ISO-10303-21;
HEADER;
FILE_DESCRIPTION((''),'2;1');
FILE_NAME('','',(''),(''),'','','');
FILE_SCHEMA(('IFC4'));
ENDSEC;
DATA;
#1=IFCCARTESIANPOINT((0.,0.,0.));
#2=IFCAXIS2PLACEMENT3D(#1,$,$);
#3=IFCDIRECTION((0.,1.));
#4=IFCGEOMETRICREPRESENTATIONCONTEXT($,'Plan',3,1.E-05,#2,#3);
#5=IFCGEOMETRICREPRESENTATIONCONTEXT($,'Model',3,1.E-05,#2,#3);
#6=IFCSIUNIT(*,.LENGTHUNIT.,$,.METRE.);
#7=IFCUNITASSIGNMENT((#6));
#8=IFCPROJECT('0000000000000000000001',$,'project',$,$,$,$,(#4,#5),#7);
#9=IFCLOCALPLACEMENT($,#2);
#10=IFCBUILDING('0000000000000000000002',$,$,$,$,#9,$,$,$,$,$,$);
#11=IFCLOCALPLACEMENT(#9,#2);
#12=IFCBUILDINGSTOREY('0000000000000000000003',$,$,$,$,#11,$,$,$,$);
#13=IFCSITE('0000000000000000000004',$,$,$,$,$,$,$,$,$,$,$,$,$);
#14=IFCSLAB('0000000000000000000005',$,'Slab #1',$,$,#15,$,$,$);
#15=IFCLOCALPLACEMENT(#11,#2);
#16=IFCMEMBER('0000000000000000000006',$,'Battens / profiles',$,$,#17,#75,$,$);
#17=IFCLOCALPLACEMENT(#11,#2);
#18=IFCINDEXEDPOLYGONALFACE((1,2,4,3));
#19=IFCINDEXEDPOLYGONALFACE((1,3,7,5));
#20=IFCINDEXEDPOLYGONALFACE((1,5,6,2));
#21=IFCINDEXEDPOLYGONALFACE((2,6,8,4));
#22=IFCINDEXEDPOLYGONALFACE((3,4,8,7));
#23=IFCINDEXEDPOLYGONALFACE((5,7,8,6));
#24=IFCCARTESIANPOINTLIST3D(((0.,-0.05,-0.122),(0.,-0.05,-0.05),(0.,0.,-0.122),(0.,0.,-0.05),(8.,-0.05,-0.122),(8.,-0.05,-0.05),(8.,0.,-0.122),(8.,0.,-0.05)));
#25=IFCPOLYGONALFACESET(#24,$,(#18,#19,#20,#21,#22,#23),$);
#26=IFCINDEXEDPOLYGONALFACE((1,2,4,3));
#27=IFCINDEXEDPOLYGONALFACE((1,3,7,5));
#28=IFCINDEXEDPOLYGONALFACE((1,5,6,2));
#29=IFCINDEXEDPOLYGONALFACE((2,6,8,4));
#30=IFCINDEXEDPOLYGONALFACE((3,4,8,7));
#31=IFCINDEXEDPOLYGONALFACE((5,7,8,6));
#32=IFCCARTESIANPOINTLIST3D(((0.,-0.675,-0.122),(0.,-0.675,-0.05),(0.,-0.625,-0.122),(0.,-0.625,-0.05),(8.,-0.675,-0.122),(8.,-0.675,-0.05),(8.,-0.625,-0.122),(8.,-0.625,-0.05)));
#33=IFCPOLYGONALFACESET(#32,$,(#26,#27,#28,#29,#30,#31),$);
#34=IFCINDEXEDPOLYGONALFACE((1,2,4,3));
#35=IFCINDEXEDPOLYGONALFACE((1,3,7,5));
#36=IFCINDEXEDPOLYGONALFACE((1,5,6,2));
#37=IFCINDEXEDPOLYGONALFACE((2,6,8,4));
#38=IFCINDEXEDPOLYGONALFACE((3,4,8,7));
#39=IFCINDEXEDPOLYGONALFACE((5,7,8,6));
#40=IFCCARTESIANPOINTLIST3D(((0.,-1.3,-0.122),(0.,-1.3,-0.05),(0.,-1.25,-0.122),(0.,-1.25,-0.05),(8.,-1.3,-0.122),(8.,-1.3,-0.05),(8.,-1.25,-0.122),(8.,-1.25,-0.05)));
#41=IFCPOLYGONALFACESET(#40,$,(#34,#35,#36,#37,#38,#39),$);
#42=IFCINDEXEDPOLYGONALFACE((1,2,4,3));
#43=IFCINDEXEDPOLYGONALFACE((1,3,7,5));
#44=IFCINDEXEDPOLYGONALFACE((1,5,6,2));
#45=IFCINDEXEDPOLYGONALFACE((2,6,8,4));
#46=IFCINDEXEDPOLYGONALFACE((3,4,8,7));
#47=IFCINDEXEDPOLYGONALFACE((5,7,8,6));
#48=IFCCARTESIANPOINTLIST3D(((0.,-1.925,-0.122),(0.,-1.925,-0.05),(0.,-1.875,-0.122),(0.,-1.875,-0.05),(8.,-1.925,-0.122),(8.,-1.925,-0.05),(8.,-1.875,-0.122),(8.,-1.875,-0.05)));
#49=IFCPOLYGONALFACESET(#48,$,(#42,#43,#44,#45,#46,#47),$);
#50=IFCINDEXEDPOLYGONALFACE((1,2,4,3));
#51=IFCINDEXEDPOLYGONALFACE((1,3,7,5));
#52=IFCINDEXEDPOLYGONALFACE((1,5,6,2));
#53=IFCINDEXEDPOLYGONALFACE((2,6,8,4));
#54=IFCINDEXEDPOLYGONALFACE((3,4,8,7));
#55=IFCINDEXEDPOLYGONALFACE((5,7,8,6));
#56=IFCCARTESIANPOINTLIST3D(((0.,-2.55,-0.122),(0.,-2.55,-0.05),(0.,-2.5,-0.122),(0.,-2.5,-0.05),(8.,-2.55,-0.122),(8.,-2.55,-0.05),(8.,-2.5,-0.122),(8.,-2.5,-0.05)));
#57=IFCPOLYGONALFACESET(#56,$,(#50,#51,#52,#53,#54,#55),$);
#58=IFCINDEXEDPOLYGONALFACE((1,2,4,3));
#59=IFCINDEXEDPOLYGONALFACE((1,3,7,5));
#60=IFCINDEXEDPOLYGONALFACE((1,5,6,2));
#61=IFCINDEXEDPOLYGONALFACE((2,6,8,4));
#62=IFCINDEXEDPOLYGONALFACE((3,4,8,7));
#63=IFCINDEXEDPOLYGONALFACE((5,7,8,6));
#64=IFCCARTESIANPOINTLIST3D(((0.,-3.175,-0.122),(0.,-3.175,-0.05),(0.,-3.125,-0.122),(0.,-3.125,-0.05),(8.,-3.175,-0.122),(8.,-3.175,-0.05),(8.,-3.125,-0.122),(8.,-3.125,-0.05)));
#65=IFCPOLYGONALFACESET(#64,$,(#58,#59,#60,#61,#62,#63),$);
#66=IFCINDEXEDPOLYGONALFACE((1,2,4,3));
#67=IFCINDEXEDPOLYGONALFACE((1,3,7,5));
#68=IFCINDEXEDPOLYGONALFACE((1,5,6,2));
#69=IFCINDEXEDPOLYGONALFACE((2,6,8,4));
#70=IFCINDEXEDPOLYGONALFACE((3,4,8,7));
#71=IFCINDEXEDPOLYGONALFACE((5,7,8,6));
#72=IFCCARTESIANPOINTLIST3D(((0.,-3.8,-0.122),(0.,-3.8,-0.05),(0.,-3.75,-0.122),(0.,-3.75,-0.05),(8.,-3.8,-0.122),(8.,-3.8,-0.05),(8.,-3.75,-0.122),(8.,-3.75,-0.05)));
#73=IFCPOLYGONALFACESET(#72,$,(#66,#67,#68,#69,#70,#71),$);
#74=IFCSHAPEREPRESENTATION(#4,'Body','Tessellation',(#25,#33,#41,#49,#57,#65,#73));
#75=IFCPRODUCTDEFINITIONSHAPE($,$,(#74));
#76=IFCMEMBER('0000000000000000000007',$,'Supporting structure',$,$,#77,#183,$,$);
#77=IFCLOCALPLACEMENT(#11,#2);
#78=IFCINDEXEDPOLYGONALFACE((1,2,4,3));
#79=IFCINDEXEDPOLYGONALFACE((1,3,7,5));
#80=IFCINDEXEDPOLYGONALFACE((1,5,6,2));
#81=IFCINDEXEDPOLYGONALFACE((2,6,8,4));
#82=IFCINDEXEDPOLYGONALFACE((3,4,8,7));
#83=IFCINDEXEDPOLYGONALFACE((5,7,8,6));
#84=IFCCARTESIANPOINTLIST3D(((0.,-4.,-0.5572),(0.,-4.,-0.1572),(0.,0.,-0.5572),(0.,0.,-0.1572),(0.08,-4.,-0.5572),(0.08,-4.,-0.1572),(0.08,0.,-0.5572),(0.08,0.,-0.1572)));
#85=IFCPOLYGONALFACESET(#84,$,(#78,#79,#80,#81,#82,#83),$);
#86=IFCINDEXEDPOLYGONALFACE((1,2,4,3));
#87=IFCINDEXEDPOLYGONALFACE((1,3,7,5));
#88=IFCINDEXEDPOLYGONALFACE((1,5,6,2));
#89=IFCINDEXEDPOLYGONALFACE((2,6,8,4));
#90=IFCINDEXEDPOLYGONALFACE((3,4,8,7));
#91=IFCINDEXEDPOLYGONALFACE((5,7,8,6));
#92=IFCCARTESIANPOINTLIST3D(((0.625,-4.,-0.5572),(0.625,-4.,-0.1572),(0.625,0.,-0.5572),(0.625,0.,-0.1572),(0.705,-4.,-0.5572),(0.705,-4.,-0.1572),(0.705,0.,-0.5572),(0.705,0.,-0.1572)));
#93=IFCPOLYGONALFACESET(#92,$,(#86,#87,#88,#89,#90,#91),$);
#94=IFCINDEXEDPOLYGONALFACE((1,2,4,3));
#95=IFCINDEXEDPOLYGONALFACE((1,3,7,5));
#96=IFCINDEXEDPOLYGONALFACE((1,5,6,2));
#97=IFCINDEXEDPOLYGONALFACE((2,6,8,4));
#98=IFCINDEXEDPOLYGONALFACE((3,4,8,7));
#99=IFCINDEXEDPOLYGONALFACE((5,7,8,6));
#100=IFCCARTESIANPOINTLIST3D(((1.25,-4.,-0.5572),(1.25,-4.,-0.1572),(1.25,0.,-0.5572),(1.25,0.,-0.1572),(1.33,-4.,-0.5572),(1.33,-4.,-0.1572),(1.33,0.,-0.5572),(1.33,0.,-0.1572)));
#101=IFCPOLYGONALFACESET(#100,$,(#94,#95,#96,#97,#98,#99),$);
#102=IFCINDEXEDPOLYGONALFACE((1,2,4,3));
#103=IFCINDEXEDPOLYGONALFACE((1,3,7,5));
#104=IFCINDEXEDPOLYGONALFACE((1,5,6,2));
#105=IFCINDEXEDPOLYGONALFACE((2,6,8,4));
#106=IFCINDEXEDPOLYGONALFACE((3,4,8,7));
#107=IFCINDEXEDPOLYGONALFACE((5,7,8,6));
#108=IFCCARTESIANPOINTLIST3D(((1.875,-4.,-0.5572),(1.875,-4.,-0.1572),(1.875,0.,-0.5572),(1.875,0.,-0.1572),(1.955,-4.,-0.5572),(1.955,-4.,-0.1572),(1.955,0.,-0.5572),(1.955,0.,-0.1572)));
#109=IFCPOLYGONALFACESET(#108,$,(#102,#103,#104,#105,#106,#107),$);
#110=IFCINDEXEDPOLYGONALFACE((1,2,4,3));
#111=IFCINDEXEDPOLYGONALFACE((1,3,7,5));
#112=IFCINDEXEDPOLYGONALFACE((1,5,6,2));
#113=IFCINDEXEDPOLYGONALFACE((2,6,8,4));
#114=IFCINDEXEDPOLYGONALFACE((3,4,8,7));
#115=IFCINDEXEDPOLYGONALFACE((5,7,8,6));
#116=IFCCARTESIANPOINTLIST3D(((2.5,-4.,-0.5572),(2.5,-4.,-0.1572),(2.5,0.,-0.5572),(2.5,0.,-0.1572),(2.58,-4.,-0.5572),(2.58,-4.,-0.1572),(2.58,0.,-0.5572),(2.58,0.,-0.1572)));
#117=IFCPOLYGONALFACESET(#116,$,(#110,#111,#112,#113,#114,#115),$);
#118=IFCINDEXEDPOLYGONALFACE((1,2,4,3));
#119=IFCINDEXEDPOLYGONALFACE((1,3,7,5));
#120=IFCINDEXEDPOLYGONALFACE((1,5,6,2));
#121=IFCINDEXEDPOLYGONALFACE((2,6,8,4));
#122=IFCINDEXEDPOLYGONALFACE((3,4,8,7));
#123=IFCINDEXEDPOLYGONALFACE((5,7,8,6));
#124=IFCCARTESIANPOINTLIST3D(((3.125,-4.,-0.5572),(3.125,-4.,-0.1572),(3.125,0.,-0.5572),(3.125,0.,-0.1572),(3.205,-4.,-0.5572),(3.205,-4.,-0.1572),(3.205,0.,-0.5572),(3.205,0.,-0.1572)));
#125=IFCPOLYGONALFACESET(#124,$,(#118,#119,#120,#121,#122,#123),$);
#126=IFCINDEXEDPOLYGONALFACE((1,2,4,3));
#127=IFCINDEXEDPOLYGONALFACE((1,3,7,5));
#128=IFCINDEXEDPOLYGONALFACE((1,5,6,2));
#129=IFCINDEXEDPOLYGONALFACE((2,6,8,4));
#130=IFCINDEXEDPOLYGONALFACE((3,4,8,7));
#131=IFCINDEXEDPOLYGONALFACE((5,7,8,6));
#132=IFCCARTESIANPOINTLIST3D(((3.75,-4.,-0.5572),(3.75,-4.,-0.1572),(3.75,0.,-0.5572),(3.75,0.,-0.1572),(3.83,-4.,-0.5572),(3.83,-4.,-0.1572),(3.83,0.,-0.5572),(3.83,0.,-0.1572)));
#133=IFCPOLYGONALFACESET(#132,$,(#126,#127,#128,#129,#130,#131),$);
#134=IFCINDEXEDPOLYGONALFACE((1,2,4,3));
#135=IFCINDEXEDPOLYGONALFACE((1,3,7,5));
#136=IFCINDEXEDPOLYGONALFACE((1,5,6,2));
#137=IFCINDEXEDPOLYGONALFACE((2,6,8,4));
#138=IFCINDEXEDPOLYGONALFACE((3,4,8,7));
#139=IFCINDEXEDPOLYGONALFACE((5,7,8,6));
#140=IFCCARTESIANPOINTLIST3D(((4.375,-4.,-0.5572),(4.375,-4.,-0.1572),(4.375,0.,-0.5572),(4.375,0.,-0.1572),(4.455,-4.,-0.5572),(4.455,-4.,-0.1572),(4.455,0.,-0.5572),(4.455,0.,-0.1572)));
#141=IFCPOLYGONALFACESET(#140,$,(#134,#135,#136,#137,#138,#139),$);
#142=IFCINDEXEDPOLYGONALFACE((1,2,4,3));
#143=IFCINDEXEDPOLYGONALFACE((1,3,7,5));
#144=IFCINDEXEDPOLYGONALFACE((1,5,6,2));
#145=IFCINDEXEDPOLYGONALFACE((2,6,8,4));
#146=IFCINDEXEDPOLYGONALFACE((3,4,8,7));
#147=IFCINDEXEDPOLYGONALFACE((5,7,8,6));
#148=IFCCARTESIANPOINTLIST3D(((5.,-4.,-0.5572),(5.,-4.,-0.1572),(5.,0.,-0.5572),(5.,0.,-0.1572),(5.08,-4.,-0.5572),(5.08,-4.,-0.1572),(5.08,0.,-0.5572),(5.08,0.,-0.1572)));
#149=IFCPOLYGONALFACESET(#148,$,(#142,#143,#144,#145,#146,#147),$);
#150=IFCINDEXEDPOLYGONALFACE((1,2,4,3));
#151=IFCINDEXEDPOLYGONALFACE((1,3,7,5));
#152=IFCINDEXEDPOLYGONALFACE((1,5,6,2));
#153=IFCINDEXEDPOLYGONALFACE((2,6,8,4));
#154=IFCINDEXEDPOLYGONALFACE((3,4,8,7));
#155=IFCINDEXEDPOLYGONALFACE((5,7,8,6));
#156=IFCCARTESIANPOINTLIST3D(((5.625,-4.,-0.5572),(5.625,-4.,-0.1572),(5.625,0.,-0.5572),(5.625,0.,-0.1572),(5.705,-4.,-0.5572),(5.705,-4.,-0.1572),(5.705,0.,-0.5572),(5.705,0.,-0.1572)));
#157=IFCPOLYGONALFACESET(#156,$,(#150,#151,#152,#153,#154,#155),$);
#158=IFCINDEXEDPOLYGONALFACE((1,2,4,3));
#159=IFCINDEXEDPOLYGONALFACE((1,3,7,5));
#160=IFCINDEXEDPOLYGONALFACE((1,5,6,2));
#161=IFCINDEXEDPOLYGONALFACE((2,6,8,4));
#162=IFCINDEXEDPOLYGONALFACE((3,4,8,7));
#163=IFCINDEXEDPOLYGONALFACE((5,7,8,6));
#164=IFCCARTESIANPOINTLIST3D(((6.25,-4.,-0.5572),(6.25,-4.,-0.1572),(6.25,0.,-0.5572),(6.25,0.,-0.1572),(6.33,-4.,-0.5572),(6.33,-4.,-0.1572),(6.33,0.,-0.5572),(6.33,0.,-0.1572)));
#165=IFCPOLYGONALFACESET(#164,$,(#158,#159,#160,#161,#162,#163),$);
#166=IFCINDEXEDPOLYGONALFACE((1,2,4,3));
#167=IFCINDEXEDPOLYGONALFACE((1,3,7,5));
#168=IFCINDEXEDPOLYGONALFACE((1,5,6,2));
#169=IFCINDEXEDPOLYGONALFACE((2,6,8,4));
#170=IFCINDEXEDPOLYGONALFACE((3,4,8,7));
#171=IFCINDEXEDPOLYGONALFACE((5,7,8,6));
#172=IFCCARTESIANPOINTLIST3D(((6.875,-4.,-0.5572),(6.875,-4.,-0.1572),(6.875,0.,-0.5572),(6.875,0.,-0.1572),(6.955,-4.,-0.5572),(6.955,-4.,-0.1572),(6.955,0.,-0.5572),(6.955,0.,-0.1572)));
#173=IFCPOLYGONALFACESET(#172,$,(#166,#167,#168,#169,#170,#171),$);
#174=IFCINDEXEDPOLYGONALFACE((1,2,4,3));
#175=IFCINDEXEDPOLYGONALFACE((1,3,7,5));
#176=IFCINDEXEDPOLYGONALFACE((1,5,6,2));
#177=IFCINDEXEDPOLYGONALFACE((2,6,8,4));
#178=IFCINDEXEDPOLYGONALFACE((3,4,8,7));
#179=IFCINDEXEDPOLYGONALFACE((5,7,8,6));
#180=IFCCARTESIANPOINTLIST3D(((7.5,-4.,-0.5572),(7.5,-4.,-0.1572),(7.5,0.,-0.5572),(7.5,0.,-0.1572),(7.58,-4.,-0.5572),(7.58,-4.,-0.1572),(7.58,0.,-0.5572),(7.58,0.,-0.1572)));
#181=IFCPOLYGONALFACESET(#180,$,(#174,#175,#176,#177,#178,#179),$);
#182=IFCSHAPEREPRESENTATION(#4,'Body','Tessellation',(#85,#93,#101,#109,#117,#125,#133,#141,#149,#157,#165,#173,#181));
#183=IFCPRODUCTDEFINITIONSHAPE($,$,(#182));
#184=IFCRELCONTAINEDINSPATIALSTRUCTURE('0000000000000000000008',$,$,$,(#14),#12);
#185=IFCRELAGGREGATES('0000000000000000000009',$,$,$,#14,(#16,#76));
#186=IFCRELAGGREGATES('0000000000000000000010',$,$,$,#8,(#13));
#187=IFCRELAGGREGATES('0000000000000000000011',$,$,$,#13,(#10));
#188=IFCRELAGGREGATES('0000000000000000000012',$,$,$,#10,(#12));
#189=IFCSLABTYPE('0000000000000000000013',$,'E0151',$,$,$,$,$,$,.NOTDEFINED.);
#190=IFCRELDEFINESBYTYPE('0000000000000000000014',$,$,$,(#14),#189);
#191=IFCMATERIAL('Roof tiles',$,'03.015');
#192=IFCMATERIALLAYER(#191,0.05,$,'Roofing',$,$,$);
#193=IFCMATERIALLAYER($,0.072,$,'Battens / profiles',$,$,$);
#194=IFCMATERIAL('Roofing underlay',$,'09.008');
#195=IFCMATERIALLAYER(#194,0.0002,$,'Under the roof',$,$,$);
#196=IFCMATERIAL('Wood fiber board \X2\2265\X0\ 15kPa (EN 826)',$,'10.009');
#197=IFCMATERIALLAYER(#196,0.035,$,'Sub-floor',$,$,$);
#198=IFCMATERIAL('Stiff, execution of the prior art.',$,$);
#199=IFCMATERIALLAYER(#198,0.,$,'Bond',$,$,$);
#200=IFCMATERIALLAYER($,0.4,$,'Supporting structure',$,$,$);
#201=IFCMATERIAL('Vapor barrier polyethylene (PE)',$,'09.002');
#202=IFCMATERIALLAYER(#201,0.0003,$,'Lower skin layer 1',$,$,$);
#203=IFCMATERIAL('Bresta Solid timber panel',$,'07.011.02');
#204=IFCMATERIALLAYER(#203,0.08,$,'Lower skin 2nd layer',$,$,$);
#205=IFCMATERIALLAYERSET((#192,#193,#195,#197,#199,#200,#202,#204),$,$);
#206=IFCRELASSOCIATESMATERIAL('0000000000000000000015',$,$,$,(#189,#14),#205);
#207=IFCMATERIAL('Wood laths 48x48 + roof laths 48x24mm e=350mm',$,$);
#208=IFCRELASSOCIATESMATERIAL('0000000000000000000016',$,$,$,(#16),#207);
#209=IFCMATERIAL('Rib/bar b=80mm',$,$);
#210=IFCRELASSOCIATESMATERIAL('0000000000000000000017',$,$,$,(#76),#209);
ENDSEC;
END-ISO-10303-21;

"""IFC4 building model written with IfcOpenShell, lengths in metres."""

from ifc_helpers import new_model, si_unit, direction, frame, frame_2d, origin, place, context, project, spatial, rectangle, extrude, material, layer, layer_set, type_object, element, aggregate, save


model = new_model("IFC4")

# Units and contexts
plan_context = context("Plan", 3, precision=1e-05, world=origin(), true_north=direction((0.0, 1.0)))
model_context = context("Model", 3, precision=1e-05, world=origin(), true_north=direction((0.0, 1.0)))
ifc_project = project(units=[si_unit("LENGTHUNIT", "METRE")], contexts=[plan_context, model_context])

# Site, building, storey
site = spatial("IfcSite", under=ifc_project)
building_placement = place(None, origin())
building = spatial("IfcBuilding", under=site, at=building_placement)
storey_placement = place(building_placement, origin())
storey = spatial("IfcBuildingStorey", under=building, at=storey_placement)

# Slab, members
ifc_material_1 = material(Name="Roof tiles", Category="03.015")
ifc_layer_1 = layer(ifc_material_1, 0.05, Name="Roofing")
ifc_layer_2 = layer(None, 0.072, Name="Battens / profiles")
ifc_material_2 = material(Name="Roofing underlay", Category="09.008")
ifc_layer_3 = layer(ifc_material_2, 0.0002, Name="Under the roof")
ifc_material_3 = material(Name="Wood fiber board ≥ 15kPa (EN 826)", Category="10.009")
ifc_layer_4 = layer(ifc_material_3, 0.035, Name="Sub-floor")
ifc_material_4 = material(Name="Stiff, execution of the prior art.")
ifc_layer_5 = layer(ifc_material_4, 0.0, Name="Bond")
ifc_layer_6 = layer(None, 0.4, Name="Supporting structure")
ifc_material_5 = material(Name="Vapor barrier polyethylene (PE)", Category="09.002")
ifc_layer_7 = layer(ifc_material_5, 0.0003, Name="Lower skin layer 1")
ifc_material_6 = material(Name="Bresta Solid timber panel", Category="07.011.02")
ifc_layer_8 = layer(ifc_material_6, 0.08, Name="Lower skin 2nd layer")
ifc_layer_set = layer_set([ifc_layer_1, ifc_layer_2, ifc_layer_3, ifc_layer_4, ifc_layer_5, ifc_layer_6, ifc_layer_7, ifc_layer_8])
slab_type = type_object("IfcSlabType", Name="E0151", PredefinedType="NOTDEFINED", material=ifc_layer_set)
slab_placement = place(None, frame((0.0, 0.0, 0.0), z_axis=(0.0, 0.0, -1.0), x_axis=(1.0, 0.0, 0.0)))
slab = element("IfcSlab", 1, at=slab_placement, inside=storey, type_object=slab_type, material=ifc_layer_set, Name="Slab #1")
ifc_material_7 = material(Name="Wood laths 48x48 + roof laths 48x24mm e=350mm")
member_1_placement = place(slab_placement, origin())
member_1 = element("IfcMember", 2, at=member_1_placement, material=ifc_material_7, Name="Battens / profiles", context=plan_context, shape_type="SweptSolid", body=[
    extrude(rectangle(XDim=0.05, YDim=0.072, at=frame_2d((0.025, 0.036), x_axis=(1.0, 0.0))), frame((0.0, 0.0, 0.05), z_axis=(1.0, 0.0, 0.0), x_axis=(0.0, 1.0, 0.0)), (0.0, 0.0, 1.0), 8.0),
    extrude(rectangle(XDim=0.05, YDim=0.072, at=frame_2d((0.025, 0.036), x_axis=(1.0, 0.0))), frame((0.0, 0.625, 0.05), z_axis=(1.0, 0.0, 0.0), x_axis=(0.0, 1.0, 0.0)), (0.0, 0.0, 1.0), 8.0),
    extrude(rectangle(XDim=0.05, YDim=0.072, at=frame_2d((0.025, 0.036), x_axis=(1.0, 0.0))), frame((0.0, 1.25, 0.05), z_axis=(1.0, 0.0, 0.0), x_axis=(0.0, 1.0, 0.0)), (0.0, 0.0, 1.0), 8.0),
    extrude(rectangle(XDim=0.05, YDim=0.072, at=frame_2d((0.025, 0.036), x_axis=(1.0, 0.0))), frame((0.0, 1.875, 0.05), z_axis=(1.0, 0.0, 0.0), x_axis=(0.0, 1.0, 0.0)), (0.0, 0.0, 1.0), 8.0),
    extrude(rectangle(XDim=0.05, YDim=0.072, at=frame_2d((0.025, 0.036), x_axis=(1.0, 0.0))), frame((0.0, 2.5, 0.05), z_axis=(1.0, 0.0, 0.0), x_axis=(0.0, 1.0, 0.0)), (0.0, 0.0, 1.0), 8.0),
    extrude(rectangle(XDim=0.05, YDim=0.072, at=frame_2d((0.025, 0.036), x_axis=(1.0, 0.0))), frame((0.0, 3.125, 0.05), z_axis=(1.0, 0.0, 0.0), x_axis=(0.0, 1.0, 0.0)), (0.0, 0.0, 1.0), 8.0),
    extrude(rectangle(XDim=0.05, YDim=0.072, at=frame_2d((0.025, 0.036), x_axis=(1.0, 0.0))), frame((0.0, 3.75, 0.05), z_axis=(1.0, 0.0, 0.0), x_axis=(0.0, 1.0, 0.0)), (0.0, 0.0, 1.0), 8.0),
])
ifc_material_8 = material(Name="Rib/bar b=80mm")
member_2_placement = place(slab_placement, origin())
member_2 = element("IfcMember", 3, at=member_2_placement, material=ifc_material_8, Name="Supporting structure", context=plan_context, shape_type="SweptSolid", body=[
    extrude(rectangle(XDim=0.08, YDim=0.4, at=frame_2d((0.04, 0.2), x_axis=(1.0, 0.0))), frame((0.0, 4.0, 0.1572), z_axis=(0.0, -1.0, 0.0), x_axis=(1.0, 0.0, 0.0)), (0.0, 0.0, 1.0), 4.0),
    extrude(rectangle(XDim=0.08, YDim=0.4, at=frame_2d((0.04, 0.2), x_axis=(1.0, 0.0))), frame((0.625, 4.0, 0.1572), z_axis=(0.0, -1.0, 0.0), x_axis=(1.0, 0.0, 0.0)), (0.0, 0.0, 1.0), 4.0),
    extrude(rectangle(XDim=0.08, YDim=0.4, at=frame_2d((0.04, 0.2), x_axis=(1.0, 0.0))), frame((1.25, 4.0, 0.1572), z_axis=(0.0, -1.0, 0.0), x_axis=(1.0, 0.0, 0.0)), (0.0, 0.0, 1.0), 4.0),
    extrude(rectangle(XDim=0.08, YDim=0.4, at=frame_2d((0.04, 0.2), x_axis=(1.0, 0.0))), frame((1.875, 4.0, 0.1572), z_axis=(0.0, -1.0, 0.0), x_axis=(1.0, 0.0, 0.0)), (0.0, 0.0, 1.0), 4.0),
    extrude(rectangle(XDim=0.08, YDim=0.4, at=frame_2d((0.04, 0.2), x_axis=(1.0, 0.0))), frame((2.5, 4.0, 0.1572), z_axis=(0.0, -1.0, 0.0), x_axis=(1.0, 0.0, 0.0)), (0.0, 0.0, 1.0), 4.0),
    extrude(rectangle(XDim=0.08, YDim=0.4, at=frame_2d((0.04, 0.2), x_axis=(1.0, 0.0))), frame((3.125, 4.0, 0.1572), z_axis=(0.0, -1.0, 0.0), x_axis=(1.0, 0.0, 0.0)), (0.0, 0.0, 1.0), 4.0),
    extrude(rectangle(XDim=0.08, YDim=0.4, at=frame_2d((0.04, 0.2), x_axis=(1.0, 0.0))), frame((3.75, 4.0, 0.1572), z_axis=(0.0, -1.0, 0.0), x_axis=(1.0, 0.0, 0.0)), (0.0, 0.0, 1.0), 4.0),
    extrude(rectangle(XDim=0.08, YDim=0.4, at=frame_2d((0.04, 0.2), x_axis=(1.0, 0.0))), frame((4.375, 4.0, 0.1572), z_axis=(0.0, -1.0, 0.0), x_axis=(1.0, 0.0, 0.0)), (0.0, 0.0, 1.0), 4.0),
    extrude(rectangle(XDim=0.08, YDim=0.4, at=frame_2d((0.04, 0.2), x_axis=(1.0, 0.0))), frame((5.0, 4.0, 0.1572), z_axis=(0.0, -1.0, 0.0), x_axis=(1.0, 0.0, 0.0)), (0.0, 0.0, 1.0), 4.0),
    extrude(rectangle(XDim=0.08, YDim=0.4, at=frame_2d((0.04, 0.2), x_axis=(1.0, 0.0))), frame((5.625, 4.0, 0.1572), z_axis=(0.0, -1.0, 0.0), x_axis=(1.0, 0.0, 0.0)), (0.0, 0.0, 1.0), 4.0),
    extrude(rectangle(XDim=0.08, YDim=0.4, at=frame_2d((0.04, 0.2), x_axis=(1.0, 0.0))), frame((6.25, 4.0, 0.1572), z_axis=(0.0, -1.0, 0.0), x_axis=(1.0, 0.0, 0.0)), (0.0, 0.0, 1.0), 4.0),
    extrude(rectangle(XDim=0.08, YDim=0.4, at=frame_2d((0.04, 0.2), x_axis=(1.0, 0.0))), frame((6.875, 4.0, 0.1572), z_axis=(0.0, -1.0, 0.0), x_axis=(1.0, 0.0, 0.0)), (0.0, 0.0, 1.0), 4.0),
    extrude(rectangle(XDim=0.08, YDim=0.4, at=frame_2d((0.04, 0.2), x_axis=(1.0, 0.0))), frame((7.5, 4.0, 0.1572), z_axis=(0.0, -1.0, 0.0), x_axis=(1.0, 0.0, 0.0)), (0.0, 0.0, 1.0), 4.0),
])
aggregate(slab, [member_1, member_2])

save(model, "model.ifc")
